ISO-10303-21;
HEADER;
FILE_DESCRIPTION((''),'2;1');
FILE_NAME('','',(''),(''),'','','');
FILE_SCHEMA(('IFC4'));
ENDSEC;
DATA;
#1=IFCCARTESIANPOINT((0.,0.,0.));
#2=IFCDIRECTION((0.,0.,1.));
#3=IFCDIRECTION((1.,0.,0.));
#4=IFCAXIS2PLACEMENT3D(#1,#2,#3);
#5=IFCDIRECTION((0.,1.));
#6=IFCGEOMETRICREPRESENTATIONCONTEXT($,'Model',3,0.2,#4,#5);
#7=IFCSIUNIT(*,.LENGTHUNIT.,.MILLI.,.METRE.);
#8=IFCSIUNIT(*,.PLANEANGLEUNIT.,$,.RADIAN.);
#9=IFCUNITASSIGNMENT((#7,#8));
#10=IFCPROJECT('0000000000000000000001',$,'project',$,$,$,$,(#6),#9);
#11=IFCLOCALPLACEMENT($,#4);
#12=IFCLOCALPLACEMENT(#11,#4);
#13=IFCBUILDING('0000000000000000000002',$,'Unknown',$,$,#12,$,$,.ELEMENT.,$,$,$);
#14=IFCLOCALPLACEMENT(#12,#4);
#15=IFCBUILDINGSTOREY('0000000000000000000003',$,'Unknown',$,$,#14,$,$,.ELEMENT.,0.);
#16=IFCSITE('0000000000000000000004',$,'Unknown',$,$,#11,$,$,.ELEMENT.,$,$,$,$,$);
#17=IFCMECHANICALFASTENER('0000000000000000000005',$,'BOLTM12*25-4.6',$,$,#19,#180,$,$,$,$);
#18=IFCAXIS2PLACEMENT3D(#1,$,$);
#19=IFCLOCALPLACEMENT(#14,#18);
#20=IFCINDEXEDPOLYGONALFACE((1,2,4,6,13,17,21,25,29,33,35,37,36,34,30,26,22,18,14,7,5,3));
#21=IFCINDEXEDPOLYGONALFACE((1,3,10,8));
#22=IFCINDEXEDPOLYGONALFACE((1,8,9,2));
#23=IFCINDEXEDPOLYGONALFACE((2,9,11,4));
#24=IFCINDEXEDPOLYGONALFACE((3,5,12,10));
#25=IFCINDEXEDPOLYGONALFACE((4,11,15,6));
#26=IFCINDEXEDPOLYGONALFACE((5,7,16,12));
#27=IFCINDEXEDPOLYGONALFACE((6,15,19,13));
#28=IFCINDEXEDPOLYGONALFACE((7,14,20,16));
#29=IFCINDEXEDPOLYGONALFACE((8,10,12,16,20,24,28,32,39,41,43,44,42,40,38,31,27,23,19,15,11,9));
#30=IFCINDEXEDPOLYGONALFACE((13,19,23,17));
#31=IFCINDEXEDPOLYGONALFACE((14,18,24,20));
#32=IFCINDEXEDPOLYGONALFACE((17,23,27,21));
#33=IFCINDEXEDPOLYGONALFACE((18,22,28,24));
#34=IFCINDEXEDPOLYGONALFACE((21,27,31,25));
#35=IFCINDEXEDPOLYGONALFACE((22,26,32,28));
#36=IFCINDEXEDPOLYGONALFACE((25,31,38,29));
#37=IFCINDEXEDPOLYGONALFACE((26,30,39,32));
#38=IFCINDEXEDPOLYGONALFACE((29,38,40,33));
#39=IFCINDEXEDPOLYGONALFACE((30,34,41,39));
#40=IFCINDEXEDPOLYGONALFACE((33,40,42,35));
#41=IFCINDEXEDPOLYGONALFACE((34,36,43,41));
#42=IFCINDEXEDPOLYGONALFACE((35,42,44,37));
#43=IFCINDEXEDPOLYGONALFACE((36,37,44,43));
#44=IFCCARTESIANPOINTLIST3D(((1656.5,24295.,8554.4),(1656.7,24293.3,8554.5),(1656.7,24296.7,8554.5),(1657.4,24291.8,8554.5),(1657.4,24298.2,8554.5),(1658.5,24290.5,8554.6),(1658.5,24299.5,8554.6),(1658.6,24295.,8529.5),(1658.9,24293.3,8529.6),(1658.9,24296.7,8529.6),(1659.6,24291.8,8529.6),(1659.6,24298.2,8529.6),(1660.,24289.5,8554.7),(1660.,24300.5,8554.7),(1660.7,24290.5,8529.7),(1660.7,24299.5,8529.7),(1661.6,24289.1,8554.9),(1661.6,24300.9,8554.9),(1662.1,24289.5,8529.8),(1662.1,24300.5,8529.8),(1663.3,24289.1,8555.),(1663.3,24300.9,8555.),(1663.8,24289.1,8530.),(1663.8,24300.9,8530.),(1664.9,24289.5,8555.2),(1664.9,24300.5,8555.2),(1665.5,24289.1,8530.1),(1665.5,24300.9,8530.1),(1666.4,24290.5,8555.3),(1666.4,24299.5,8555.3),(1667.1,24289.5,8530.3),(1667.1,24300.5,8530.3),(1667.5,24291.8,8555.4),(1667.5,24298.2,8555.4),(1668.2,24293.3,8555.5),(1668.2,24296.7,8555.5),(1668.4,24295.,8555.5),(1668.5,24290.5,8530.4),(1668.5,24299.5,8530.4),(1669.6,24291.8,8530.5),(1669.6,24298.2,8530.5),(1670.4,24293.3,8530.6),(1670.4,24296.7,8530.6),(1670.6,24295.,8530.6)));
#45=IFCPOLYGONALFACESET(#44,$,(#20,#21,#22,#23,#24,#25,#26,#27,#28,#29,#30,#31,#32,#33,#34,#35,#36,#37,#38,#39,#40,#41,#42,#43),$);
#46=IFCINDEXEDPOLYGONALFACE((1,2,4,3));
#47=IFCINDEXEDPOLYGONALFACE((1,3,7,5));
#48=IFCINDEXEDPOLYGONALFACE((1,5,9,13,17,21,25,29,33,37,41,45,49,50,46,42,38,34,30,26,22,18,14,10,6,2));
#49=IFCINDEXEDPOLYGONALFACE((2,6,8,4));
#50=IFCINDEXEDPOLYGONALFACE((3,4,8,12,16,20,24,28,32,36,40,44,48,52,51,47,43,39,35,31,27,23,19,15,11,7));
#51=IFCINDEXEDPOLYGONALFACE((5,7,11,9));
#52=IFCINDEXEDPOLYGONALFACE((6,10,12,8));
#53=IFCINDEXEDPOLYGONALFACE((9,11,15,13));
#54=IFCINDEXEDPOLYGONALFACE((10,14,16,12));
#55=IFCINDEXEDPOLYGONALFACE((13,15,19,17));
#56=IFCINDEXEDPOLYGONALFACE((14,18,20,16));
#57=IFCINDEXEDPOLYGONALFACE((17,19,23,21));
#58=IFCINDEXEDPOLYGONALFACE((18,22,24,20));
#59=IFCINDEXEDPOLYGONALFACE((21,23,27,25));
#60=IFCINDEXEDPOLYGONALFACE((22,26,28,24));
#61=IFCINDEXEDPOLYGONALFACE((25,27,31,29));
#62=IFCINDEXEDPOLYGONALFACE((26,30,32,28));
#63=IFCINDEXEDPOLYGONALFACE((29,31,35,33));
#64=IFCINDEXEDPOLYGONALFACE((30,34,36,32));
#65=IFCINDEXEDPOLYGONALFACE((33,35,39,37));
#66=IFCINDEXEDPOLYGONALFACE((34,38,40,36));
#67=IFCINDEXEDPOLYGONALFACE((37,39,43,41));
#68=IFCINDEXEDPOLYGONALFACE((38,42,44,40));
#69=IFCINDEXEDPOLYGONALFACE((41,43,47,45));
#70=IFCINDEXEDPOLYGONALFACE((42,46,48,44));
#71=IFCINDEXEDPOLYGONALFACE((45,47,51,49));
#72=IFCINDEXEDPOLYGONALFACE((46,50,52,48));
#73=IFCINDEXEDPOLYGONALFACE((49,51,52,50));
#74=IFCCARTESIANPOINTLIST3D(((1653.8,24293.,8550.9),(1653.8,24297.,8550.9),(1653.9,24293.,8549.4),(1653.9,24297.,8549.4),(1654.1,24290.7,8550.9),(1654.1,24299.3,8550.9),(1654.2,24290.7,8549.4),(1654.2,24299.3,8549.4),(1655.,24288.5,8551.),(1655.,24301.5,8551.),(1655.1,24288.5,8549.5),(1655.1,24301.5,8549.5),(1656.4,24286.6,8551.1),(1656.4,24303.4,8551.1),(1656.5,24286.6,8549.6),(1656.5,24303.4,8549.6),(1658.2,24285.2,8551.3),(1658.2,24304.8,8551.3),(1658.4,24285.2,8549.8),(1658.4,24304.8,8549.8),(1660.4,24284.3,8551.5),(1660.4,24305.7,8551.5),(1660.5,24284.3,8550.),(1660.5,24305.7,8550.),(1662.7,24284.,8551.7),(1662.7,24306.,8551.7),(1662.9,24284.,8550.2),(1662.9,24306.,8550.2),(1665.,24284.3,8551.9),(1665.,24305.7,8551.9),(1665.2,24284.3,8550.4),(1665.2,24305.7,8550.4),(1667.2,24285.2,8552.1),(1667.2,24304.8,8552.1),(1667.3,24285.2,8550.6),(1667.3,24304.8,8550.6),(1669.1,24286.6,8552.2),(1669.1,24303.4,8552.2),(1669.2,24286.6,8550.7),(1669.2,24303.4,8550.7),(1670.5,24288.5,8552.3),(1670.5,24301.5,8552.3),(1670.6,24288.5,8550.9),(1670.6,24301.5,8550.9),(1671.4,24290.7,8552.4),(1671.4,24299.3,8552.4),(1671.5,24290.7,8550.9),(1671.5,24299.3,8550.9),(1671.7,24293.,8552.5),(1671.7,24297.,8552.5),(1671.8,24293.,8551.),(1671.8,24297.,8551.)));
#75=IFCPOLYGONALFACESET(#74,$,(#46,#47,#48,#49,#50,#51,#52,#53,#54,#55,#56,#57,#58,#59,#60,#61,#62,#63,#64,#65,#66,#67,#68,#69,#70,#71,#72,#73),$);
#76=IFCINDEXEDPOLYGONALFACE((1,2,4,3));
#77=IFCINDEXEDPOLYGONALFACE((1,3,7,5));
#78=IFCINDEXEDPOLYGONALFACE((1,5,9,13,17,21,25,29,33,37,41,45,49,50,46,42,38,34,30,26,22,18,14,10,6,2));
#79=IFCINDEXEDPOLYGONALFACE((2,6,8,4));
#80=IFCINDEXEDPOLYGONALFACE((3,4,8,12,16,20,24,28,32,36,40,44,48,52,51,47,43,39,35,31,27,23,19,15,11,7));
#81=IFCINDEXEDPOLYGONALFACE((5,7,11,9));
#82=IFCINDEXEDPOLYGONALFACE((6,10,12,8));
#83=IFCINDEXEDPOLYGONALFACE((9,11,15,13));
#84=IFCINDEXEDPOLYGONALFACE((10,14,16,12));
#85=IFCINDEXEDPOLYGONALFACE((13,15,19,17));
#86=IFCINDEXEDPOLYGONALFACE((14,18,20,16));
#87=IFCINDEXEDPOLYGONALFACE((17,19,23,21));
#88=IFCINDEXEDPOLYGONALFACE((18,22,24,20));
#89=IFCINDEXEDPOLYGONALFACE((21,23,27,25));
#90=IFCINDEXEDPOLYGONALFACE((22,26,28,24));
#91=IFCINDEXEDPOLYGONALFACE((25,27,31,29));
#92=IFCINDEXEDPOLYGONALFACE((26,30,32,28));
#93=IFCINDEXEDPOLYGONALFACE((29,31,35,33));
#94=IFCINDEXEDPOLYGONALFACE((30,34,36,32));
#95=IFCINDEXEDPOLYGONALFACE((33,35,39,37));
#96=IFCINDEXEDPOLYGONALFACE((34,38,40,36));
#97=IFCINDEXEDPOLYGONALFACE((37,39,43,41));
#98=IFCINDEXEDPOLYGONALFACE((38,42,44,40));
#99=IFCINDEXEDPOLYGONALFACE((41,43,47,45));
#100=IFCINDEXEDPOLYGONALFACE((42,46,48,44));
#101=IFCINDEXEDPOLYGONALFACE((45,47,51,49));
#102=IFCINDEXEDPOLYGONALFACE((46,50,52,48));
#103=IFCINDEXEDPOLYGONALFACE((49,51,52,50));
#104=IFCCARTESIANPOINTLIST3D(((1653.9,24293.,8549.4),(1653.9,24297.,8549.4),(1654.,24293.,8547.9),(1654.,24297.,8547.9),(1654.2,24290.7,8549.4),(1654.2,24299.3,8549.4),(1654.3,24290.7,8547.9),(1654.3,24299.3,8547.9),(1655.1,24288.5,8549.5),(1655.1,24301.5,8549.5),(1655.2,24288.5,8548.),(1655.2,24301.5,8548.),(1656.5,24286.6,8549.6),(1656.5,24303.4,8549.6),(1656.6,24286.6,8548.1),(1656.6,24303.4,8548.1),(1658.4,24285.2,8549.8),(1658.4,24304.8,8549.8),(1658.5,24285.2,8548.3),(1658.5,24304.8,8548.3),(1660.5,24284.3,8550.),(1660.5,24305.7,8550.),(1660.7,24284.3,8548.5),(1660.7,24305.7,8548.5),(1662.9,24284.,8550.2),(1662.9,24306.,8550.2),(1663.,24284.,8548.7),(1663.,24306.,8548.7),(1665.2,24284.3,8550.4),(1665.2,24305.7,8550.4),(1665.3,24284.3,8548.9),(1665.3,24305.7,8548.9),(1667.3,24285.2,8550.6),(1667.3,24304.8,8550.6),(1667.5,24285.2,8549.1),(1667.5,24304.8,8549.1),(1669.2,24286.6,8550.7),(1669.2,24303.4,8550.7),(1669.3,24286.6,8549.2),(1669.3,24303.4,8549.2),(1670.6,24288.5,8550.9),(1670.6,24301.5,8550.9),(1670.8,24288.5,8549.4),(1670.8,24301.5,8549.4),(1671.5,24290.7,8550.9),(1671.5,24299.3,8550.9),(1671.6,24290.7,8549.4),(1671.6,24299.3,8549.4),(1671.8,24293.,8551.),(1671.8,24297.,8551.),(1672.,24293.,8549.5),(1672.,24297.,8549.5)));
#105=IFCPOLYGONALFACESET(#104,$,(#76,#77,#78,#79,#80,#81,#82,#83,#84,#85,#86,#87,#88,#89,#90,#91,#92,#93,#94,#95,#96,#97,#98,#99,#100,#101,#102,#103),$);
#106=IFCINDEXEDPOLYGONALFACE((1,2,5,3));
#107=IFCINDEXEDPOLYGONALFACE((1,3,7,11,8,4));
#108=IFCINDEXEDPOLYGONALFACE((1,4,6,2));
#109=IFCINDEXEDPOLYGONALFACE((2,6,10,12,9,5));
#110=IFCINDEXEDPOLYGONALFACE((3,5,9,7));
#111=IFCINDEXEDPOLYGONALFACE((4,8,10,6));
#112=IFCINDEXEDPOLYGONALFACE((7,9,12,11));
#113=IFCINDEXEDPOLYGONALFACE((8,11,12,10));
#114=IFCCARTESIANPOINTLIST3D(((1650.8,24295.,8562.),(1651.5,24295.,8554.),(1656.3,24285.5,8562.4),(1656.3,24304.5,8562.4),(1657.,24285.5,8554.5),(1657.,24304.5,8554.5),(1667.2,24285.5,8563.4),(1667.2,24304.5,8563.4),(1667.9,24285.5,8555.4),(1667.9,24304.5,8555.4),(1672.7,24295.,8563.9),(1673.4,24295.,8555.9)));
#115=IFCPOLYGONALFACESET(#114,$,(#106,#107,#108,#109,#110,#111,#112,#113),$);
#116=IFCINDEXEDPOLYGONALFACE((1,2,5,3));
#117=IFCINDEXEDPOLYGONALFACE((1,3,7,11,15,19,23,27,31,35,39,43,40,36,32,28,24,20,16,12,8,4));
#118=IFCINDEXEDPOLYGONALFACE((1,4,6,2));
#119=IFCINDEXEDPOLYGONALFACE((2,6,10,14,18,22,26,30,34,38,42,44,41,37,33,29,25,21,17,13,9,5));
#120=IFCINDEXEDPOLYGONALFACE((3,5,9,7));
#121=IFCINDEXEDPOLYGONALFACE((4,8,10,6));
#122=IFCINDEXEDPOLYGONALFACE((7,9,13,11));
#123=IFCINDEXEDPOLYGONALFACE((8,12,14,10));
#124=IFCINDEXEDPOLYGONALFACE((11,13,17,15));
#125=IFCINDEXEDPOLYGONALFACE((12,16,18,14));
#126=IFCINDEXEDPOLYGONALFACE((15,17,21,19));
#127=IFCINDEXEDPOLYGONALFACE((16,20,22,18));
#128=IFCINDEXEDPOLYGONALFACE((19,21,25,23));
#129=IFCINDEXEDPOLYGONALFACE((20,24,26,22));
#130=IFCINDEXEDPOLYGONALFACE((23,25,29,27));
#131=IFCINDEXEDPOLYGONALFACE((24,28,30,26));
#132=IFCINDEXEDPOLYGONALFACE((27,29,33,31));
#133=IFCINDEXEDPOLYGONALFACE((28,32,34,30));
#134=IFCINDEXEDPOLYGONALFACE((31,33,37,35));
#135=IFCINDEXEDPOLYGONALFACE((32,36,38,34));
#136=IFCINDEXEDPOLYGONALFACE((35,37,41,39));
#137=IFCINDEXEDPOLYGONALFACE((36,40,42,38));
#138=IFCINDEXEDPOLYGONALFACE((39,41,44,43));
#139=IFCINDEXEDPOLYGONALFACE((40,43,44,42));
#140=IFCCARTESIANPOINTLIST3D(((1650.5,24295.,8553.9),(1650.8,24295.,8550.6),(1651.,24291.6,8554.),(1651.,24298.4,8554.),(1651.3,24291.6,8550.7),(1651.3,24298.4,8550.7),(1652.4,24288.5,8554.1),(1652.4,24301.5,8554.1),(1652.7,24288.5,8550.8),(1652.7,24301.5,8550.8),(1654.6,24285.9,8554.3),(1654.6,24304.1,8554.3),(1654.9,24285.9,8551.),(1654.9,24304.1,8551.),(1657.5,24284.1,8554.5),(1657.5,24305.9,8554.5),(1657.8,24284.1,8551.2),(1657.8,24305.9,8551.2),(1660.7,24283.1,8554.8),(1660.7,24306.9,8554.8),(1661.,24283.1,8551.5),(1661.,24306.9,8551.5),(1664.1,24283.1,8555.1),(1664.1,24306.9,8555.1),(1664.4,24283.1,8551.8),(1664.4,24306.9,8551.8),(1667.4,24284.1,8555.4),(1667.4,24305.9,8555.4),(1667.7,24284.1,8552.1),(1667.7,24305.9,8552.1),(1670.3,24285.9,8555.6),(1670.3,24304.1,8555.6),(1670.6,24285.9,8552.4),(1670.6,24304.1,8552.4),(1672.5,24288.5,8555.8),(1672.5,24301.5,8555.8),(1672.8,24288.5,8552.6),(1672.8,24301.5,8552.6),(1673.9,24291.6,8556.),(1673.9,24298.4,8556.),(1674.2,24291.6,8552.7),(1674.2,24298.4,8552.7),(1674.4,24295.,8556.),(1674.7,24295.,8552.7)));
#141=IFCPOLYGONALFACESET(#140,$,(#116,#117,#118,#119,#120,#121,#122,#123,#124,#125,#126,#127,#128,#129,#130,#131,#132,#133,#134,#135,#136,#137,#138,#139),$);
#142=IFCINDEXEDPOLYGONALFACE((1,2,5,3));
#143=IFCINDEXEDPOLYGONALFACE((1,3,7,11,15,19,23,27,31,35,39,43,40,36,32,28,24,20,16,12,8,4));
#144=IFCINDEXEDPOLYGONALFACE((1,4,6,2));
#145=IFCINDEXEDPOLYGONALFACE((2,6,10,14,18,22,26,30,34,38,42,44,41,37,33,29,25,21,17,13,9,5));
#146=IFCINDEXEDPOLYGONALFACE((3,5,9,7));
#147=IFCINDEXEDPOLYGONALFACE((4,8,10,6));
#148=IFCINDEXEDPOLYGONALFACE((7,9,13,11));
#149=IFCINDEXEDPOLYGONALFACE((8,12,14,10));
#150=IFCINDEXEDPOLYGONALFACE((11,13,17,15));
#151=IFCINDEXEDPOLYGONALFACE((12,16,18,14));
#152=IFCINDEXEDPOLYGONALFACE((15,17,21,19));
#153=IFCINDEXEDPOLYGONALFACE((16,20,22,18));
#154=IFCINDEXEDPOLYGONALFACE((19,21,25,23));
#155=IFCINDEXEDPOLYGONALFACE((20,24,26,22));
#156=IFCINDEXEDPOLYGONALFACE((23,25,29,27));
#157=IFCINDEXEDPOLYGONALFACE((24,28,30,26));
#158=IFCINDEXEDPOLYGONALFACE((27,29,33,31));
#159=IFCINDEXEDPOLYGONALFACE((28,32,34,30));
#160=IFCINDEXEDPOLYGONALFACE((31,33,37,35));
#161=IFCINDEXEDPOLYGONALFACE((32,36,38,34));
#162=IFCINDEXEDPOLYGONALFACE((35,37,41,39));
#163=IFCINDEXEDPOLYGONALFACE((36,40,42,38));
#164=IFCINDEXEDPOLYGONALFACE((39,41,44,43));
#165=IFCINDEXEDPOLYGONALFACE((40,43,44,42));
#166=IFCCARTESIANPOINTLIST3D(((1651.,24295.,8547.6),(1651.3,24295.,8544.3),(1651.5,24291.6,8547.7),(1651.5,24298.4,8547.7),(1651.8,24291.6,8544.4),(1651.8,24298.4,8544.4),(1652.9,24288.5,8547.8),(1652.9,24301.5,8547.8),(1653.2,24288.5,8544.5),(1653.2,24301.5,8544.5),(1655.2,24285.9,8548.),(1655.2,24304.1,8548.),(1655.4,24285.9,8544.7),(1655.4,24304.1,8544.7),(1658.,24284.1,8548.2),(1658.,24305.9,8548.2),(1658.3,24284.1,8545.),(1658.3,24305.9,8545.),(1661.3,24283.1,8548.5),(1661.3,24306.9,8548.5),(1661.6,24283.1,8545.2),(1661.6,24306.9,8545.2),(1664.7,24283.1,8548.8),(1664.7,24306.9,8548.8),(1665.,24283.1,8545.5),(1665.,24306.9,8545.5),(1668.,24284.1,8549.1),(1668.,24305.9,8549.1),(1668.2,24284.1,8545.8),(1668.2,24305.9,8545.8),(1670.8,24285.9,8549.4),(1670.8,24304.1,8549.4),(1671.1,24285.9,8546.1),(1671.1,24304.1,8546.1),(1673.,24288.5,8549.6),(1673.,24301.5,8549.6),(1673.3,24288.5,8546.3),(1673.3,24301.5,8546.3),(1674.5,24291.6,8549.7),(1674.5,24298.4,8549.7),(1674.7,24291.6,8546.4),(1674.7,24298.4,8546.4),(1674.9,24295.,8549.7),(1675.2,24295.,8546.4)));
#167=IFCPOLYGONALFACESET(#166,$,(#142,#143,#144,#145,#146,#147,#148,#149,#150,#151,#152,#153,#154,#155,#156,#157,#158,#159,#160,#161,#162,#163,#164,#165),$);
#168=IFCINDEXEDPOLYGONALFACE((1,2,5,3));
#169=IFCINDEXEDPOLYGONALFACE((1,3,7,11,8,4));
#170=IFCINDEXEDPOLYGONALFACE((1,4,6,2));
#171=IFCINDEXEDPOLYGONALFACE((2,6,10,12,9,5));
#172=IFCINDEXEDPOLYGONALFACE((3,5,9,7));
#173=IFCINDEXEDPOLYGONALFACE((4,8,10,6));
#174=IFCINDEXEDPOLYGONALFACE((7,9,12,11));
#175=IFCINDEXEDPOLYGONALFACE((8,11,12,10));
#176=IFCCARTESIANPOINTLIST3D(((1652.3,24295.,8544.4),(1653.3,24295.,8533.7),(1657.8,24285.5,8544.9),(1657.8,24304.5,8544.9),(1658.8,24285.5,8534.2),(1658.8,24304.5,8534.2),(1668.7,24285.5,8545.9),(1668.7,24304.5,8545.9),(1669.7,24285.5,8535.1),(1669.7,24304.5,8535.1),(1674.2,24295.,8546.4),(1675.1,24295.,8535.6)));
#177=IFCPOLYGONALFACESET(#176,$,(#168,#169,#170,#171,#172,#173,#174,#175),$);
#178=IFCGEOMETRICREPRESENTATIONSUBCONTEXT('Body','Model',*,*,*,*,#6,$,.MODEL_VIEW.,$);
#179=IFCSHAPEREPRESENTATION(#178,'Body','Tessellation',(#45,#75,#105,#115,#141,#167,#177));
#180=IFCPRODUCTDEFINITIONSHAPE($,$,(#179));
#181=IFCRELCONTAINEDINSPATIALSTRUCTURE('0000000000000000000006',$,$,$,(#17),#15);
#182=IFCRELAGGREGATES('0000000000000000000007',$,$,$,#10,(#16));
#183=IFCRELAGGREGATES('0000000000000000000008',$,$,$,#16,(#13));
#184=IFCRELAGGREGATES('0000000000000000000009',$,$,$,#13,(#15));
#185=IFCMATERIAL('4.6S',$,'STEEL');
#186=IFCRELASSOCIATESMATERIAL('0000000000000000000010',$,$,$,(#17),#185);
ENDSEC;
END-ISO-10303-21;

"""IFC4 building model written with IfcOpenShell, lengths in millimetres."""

from ifc_helpers import new_model, si_unit, direction, frame, origin_with_axes, place, context, subcontext, project, spatial, line, arc, indexed_curve, outline, extrude, source, transform, mapped, material, element, save


model = new_model("IFC4")

# Units and contexts
model_context = context("Model", 3, precision=0.2, world=origin_with_axes(), true_north=direction((0.0, 1.0)))
body_context = subcontext(model_context, "Body", "Model", "MODEL_VIEW")
ifc_project = project(units=[si_unit("LENGTHUNIT", "METRE", prefix="MILLI"), si_unit("PLANEANGLEUNIT", "RADIAN")], contexts=[model_context])

# Site, building, storey
site_placement = place(None, origin_with_axes())
site = spatial("IfcSite", under=ifc_project, at=site_placement, Name="Unknown", CompositionType="ELEMENT")
building_placement = place(site_placement, origin_with_axes())
building = spatial("IfcBuilding", under=site, at=building_placement, Name="Unknown", CompositionType="ELEMENT")
storey_placement = place(building_placement, origin_with_axes())
storey = spatial("IfcBuildingStorey", under=building, at=storey_placement, Name="Unknown", CompositionType="ELEMENT", Elevation=0.0)

# Mechanical fastener
ifc_material_1 = material(Name="4.6S", Category="STEEL")
shared_shape_1 = source(origin_with_axes(), body_context, "Body", "SweptSolid", [
    extrude(outline(indexed_curve([(6.0, 0.0), (0.0, 6.0), (-6.0, 0.0), (0.0, -6.0)], segments=[arc(1, 2, 3), arc(3, 4, 1)])), frame((0.0, 0.0, 4.8), z_axis=(0.0, 0.0, -1.0), x_axis=(0.0, 1.0, 0.0)), (0.0, 0.0, 1.0), 25.0),
    extrude(outline(indexed_curve([(0.0, 11.0), (6.4, 8.4), (9.0, 2.0), (9.0, -2.0), (6.4, -8.4), (0.0, -11.0), (-0.8, -11.0), (-9.0, -2.0), (-9.0, 2.0), (-6.4, 8.4)], segments=[arc(1, 2, 3), line(3, 4), arc(4, 5, 6), arc(6, 7, 8), line(8, 9), arc(9, 10, 1)])), frame((0.0, 0.0, 1.5), z_axis=(0.0, 0.0, -1.0), x_axis=(0.0, 1.0, 0.0)), (0.0, 0.0, 1.0), 1.5),
    extrude(outline(indexed_curve([(0.0, 11.0), (6.4, 8.4), (9.0, 2.0), (9.0, -2.0), (6.4, -8.4), (0.0, -11.0), (-0.8, -11.0), (-9.0, -2.0), (-9.0, 2.0), (-6.4, 8.4)], segments=[arc(1, 2, 3), line(3, 4), arc(4, 5, 6), arc(6, 7, 8), line(8, 9), arc(9, 10, 1)])), frame((0.0, 0.0, 0.0), z_axis=(0.0, 0.0, -1.0), x_axis=(0.0, 1.0, 0.0)), (0.0, 0.0, 1.0), 1.5),
    extrude(outline(indexed_curve([(11.0, 0.0), (5.5, 9.5), (-5.5, 9.5), (-11.0, 0.0), (-5.5, -9.5), (5.5, -9.5)], segments=[line(1, 2, 3, 4, 5, 6, 1)])), frame((0.0, 0.0, 12.8), z_axis=(0.0, 0.0, -1.0), x_axis=(0.0, 1.0, 0.0)), (0.0, 0.0, 1.0), 8.0),
    extrude(outline(indexed_curve([(12.0, 0.0), (0.0, 12.0), (-12.0, 0.0), (0.0, -12.0)], segments=[arc(1, 2, 3), arc(3, 4, 1)])), frame((0.0, 0.0, 4.8), z_axis=(0.0, 0.0, -1.0), x_axis=(0.0, 1.0, 0.0)), (0.0, 0.0, 1.0), 3.3),
    extrude(outline(indexed_curve([(12.0, 0.0), (0.0, 12.0), (-12.0, 0.0), (0.0, -12.0)], segments=[arc(1, 2, 3), arc(3, 4, 1)])), frame((0.0, 0.0, -1.5), z_axis=(0.0, 0.0, -1.0), x_axis=(0.0, 1.0, 0.0)), (0.0, 0.0, 1.0), 3.3),
    extrude(outline(indexed_curve([(11.0, 0.0), (5.5, 9.5), (-5.5, 9.5), (-11.0, 0.0), (-5.5, -9.5), (5.5, -9.5)], segments=[line(1, 2, 3, 4, 5, 6, 1)])), frame((0.0, 0.0, -4.8), z_axis=(0.0, 0.0, -1.0), x_axis=(0.0, 1.0, 0.0)), (0.0, 0.0, 1.0), 10.8),
])
for number, where, z_axis, x_axis, name in (
    (1, (1662.9, 24295.0, 8550.2), (-0.08716, 0.0, 0.996194), (0.0, 1.0, 0.0), "BOLTM12*25-4.6"),
):
    element("IfcMechanicalFastener", number, at=place(storey_placement, frame(where, z_axis=z_axis, x_axis=x_axis)), inside=storey, material=ifc_material_1, Name=name, context=body_context, shape_type="MappedRepresentation", body=[
        mapped(shared_shape_1, transform((0.0, 0.0, 0.0))),
    ])

save(model, "model.ifc")
